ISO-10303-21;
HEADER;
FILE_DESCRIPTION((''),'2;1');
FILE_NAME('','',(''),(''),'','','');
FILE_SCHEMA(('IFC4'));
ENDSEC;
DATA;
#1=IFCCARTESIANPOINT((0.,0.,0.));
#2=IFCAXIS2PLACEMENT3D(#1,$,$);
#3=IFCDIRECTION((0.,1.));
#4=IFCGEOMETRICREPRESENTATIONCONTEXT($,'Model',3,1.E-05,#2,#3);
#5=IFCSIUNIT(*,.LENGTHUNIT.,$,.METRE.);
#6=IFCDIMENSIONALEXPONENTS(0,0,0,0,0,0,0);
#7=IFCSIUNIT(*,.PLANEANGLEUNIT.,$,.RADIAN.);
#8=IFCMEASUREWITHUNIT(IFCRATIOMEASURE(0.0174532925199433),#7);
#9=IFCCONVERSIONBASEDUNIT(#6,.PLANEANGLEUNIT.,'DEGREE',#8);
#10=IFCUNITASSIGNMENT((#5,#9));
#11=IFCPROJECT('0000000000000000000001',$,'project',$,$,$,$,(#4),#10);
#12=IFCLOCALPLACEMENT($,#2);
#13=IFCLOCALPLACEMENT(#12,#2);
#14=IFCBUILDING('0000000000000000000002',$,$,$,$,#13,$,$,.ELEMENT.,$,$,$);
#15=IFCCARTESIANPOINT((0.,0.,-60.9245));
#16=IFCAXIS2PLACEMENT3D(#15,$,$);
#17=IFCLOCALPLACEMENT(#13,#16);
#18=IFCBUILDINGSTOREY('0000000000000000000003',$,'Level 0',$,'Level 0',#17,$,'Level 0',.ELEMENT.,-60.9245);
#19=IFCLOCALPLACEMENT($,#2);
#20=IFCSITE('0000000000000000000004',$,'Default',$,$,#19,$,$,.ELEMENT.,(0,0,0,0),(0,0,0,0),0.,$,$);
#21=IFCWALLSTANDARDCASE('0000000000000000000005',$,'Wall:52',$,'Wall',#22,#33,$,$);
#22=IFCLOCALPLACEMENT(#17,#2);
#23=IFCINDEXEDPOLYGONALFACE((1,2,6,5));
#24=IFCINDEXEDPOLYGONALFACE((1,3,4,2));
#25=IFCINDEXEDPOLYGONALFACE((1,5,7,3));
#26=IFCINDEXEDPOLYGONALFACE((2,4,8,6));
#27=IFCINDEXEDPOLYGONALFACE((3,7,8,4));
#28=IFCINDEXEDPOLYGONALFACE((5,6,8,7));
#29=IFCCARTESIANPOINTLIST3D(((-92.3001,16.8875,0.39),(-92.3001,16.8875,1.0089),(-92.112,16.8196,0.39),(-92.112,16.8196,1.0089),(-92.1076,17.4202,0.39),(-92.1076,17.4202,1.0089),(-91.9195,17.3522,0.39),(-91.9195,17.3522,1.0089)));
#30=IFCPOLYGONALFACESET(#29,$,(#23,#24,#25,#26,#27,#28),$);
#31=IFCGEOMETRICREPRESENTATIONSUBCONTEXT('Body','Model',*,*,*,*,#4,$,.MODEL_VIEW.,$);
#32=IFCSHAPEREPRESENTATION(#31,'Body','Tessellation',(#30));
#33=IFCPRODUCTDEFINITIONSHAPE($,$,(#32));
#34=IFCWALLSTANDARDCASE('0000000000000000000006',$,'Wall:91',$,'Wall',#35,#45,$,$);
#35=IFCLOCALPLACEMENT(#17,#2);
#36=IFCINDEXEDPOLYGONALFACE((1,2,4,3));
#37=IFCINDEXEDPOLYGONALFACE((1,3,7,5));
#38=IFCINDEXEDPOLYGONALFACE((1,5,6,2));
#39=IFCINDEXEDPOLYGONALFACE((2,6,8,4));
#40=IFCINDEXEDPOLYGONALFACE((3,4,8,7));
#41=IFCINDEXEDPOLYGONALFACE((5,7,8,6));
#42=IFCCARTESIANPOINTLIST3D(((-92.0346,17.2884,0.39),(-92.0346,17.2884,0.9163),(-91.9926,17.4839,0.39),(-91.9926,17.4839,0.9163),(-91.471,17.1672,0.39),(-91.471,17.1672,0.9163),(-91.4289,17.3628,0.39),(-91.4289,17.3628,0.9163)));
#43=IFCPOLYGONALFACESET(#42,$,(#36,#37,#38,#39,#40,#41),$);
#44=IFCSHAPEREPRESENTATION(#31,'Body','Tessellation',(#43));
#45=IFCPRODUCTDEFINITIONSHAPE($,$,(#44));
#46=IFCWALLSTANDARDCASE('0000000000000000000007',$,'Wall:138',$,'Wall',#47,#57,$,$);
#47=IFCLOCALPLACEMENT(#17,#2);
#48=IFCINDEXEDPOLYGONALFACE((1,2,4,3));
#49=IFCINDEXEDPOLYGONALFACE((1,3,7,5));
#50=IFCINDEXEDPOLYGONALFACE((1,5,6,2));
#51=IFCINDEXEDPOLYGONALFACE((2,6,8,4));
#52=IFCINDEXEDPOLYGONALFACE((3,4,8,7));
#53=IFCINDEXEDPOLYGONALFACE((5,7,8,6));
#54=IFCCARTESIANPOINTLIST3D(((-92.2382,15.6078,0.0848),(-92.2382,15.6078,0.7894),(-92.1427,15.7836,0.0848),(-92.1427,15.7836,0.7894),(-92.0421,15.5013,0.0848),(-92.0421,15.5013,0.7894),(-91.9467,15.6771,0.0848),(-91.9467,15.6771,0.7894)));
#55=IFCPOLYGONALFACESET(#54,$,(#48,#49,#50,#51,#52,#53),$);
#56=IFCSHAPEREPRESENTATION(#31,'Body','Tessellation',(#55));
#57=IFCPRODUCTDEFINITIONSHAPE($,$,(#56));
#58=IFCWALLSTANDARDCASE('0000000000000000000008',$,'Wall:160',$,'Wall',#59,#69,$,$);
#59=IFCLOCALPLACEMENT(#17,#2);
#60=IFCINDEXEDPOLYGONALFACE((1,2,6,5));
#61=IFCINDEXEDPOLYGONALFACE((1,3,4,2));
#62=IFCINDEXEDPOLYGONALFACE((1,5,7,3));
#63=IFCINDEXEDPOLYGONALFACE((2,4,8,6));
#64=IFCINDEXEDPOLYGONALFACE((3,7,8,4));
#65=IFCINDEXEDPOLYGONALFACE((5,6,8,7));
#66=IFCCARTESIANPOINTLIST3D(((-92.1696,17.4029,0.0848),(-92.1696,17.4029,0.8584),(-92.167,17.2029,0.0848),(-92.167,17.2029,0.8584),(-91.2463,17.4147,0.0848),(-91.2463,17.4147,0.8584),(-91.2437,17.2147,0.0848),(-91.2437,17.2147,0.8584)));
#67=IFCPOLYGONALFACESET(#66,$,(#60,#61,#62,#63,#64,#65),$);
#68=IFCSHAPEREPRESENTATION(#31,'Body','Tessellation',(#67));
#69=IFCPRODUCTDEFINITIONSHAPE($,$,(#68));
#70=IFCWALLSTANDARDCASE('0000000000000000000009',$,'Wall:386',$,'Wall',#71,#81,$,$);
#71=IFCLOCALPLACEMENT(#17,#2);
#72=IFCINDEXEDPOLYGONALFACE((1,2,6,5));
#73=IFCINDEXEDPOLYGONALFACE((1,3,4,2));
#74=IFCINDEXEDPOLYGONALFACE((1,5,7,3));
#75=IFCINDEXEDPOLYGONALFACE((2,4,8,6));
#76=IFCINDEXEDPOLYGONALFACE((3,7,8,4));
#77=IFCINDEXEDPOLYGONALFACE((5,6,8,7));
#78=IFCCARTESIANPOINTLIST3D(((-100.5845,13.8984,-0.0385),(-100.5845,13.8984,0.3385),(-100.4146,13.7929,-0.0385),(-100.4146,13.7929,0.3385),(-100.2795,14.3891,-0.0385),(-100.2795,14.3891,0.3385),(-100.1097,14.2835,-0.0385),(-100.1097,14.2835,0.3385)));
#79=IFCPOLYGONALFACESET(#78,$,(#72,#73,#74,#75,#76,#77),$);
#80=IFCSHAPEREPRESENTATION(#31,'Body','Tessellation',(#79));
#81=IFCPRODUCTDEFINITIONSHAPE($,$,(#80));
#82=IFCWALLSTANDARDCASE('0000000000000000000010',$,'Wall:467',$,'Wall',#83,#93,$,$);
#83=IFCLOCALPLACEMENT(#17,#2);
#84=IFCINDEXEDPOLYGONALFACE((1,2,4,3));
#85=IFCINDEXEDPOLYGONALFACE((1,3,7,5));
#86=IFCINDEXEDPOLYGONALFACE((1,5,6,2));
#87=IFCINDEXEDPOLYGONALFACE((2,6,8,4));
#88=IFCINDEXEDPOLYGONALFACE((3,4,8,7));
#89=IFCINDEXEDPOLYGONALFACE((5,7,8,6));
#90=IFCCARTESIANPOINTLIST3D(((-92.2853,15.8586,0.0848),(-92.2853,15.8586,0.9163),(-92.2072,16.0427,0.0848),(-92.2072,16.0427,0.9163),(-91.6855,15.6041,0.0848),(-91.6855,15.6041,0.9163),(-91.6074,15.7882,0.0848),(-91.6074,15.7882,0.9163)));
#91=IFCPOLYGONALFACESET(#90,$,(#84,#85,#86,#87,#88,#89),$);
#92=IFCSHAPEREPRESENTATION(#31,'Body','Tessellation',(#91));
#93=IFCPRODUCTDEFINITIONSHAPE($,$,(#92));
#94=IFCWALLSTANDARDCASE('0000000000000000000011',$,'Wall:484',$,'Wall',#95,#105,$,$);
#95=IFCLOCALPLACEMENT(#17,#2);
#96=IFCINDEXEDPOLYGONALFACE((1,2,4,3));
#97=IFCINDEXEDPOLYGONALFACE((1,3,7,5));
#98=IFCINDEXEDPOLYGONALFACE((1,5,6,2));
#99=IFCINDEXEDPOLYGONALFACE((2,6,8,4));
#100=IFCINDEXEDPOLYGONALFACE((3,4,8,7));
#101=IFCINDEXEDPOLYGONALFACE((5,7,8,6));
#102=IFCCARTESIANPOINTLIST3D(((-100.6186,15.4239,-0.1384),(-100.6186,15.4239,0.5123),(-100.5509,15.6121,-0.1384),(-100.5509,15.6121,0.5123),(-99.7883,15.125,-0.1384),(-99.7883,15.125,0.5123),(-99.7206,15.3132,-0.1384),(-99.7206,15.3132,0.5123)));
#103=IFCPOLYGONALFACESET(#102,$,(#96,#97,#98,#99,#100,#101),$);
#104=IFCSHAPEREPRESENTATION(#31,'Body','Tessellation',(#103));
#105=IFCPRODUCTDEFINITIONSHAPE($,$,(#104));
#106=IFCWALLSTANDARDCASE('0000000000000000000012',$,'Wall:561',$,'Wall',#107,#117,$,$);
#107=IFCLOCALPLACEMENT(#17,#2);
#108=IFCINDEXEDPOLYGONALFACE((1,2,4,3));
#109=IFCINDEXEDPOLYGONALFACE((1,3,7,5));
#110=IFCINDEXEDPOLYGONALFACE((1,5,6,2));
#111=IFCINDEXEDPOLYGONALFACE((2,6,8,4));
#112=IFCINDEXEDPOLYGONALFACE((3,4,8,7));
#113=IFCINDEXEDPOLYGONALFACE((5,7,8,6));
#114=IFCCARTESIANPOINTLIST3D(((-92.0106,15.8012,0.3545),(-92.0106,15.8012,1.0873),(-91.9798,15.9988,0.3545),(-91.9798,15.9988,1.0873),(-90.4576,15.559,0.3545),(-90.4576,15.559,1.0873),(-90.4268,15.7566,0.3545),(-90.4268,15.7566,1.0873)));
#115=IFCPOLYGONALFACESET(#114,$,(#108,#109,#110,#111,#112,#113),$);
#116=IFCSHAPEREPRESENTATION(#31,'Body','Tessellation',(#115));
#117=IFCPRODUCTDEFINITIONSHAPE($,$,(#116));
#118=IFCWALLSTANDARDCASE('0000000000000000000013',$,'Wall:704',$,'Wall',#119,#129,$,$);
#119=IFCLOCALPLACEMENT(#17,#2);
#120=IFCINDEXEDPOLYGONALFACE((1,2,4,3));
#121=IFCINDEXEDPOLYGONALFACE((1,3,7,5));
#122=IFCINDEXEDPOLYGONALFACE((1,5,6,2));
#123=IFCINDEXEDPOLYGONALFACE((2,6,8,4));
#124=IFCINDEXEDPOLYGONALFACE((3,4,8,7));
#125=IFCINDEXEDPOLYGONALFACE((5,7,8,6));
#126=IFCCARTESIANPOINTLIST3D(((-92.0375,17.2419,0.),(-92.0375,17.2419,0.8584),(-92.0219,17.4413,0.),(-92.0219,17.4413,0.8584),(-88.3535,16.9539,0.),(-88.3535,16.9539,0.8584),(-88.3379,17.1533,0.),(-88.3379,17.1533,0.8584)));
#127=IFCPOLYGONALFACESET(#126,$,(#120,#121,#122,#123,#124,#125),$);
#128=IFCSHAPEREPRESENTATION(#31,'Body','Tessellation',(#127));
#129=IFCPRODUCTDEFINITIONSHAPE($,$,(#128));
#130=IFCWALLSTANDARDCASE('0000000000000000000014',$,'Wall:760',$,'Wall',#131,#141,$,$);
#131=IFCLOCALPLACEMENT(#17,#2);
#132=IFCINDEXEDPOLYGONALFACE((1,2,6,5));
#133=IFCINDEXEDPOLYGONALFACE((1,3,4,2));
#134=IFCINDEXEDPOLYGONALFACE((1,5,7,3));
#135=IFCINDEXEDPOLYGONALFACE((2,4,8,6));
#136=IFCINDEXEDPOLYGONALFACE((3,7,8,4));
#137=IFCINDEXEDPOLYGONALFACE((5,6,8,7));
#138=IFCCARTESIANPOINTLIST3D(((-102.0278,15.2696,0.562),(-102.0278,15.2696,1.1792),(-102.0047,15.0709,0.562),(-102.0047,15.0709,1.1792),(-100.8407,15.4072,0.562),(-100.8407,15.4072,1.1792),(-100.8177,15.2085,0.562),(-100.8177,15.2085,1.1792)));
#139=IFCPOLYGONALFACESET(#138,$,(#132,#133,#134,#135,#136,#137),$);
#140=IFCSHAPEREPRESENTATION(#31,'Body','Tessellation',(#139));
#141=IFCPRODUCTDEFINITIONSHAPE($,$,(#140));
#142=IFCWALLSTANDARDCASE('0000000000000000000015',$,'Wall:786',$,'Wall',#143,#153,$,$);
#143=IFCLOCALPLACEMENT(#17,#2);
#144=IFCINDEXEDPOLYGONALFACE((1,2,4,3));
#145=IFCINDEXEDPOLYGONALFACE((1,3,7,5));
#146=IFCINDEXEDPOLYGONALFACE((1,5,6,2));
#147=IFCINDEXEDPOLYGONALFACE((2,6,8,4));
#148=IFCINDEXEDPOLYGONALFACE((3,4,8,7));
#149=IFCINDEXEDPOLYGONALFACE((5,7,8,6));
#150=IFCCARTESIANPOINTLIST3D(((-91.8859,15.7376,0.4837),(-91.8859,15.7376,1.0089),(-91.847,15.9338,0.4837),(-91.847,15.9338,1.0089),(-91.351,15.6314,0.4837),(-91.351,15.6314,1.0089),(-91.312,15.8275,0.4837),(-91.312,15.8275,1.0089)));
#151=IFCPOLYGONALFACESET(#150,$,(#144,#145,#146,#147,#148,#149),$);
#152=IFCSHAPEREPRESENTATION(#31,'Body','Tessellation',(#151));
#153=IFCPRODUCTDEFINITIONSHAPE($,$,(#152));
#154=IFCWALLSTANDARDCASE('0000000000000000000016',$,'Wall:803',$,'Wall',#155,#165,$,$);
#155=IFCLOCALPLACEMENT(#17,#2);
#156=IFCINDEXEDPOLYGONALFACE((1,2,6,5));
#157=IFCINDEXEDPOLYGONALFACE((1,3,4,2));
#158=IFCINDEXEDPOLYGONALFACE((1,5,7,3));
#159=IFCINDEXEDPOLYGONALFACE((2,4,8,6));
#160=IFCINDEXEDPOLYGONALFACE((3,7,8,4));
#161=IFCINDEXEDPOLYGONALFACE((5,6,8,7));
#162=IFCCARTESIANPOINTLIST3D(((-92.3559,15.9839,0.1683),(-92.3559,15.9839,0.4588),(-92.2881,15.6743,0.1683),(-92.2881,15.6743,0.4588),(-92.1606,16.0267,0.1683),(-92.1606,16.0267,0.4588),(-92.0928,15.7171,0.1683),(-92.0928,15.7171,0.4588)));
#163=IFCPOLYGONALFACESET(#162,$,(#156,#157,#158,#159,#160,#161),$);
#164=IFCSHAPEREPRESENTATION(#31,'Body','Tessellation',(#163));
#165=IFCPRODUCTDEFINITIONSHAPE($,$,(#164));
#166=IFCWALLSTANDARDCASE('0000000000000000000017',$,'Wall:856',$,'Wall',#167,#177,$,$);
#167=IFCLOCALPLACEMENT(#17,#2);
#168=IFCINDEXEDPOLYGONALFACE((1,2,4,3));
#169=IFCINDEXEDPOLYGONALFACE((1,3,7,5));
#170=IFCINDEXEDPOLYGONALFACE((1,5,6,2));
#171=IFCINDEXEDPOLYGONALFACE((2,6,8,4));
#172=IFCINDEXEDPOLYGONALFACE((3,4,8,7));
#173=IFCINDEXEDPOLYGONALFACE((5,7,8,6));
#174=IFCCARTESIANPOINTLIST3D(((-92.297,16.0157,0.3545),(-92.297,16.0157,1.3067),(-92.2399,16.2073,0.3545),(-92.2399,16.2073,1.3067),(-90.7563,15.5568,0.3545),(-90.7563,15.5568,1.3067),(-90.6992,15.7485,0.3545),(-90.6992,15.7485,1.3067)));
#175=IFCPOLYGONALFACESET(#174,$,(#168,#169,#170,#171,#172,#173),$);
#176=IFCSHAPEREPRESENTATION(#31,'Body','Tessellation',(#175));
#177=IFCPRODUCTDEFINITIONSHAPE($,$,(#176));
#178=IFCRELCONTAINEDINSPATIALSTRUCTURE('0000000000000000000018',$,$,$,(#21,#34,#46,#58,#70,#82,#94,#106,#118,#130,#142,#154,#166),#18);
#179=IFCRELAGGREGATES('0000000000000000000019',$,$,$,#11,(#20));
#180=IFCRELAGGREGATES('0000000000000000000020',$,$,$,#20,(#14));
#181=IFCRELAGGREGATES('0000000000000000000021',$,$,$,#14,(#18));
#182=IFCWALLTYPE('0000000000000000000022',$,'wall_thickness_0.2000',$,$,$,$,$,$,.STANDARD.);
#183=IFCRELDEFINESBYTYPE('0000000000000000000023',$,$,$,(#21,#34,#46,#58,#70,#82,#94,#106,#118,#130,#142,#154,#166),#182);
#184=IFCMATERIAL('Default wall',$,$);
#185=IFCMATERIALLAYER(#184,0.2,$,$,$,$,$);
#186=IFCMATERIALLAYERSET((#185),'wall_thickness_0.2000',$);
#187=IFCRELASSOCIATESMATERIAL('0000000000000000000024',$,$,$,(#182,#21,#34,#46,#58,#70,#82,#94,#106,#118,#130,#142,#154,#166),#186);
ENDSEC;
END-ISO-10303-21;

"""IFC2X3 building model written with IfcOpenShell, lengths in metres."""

from ifc_helpers import new_model, entity, si_unit, converted_unit, direction, frame, origin, place, context, subcontext, project, spatial, polyline, outline, extrude, material, layer, layer_set, layer_usage, type_object, element, save


model = new_model("IFC2X3")

# Units and contexts
model_context = context("Model", 3, precision=1e-05, world=origin(), true_north=direction((0.0, 1.0)))
body_context = subcontext(model_context, "Body", "Model", "MODEL_VIEW")
ifc_project = project(units=[si_unit("LENGTHUNIT", "METRE"), converted_unit("PLANEANGLEUNIT", "DEGREE", entity("IfcRatioMeasure", 0.0174532925199433), si_unit("PLANEANGLEUNIT", "RADIAN"), dimensions=[0, 0, 0, 0, 0, 0, 0])], contexts=[model_context])

# Site, building, storey
site_placement = place(None, origin())
site = spatial("IfcSite", under=ifc_project, at=site_placement, Name="Default", CompositionType="ELEMENT", RefLatitude=(0, 0, 0, 0), RefLongitude=(0, 0, 0, 0), RefElevation=0.0)
placement_1 = place(None, origin())
building_placement = place(placement_1, origin())
building = spatial("IfcBuilding", under=site, at=building_placement, CompositionType="ELEMENT")
storey_placement = place(building_placement, frame((0.0, 0.0, -60.9245)))
storey = spatial("IfcBuildingStorey", under=building, at=storey_placement, Name="Level 0", ObjectType="Level 0", LongName="Level 0", CompositionType="ELEMENT", Elevation=-60.9245)

# Walls
ifc_material = material(Name="Default wall")
ifc_layer = layer(ifc_material, 0.2)
ifc_layer_set = layer_set([ifc_layer], Name="wall_thickness_0.2000")
ifc_layer_usage = layer_usage(ifc_layer_set, "AXIS2", "POSITIVE", -0.1)
wall_type = type_object("IfcWallType", Name="wall_thickness_0.2000", PredefinedType="STANDARD", material=ifc_layer_set)
placement_2 = place(building_placement, frame((0.0, 0.0, -60.5345)))
wall_1_placement = place(placement_2, frame((-92.2061, 16.8536, 0.0), z_axis=(0.0, 0.0, 1.0), x_axis=(0.339834, 0.940485, 0.0)))
element("IfcWallStandardCase", 1, at=wall_1_placement, inside=storey, type_object=wall_type, material=ifc_layer_usage, Name="Wall:52", ObjectType="Wall", context=body_context, shape_type="SweptSolid", body=[
    extrude(outline(polyline([(0.5663, -0.1), (0.5663, 0.1), (0.0, 0.1), (0.0, -0.1), (0.5663, -0.1)])), origin(), (0.0, 0.0, 1.0), 0.6189),
])
placement_3 = place(building_placement, frame((0.0, 0.0, -60.5345)))
wall_2_placement = place(placement_3, frame((-92.0136, 17.3862, 0.0), z_axis=(0.0, 0.0, 1.0), x_axis=(0.977661, -0.210187, 0.0)))
element("IfcWallStandardCase", 2, at=wall_2_placement, inside=storey, type_object=wall_type, material=ifc_layer_usage, Name="Wall:91", ObjectType="Wall", context=body_context, shape_type="SweptSolid", body=[
    extrude(outline(polyline([(0.5765, -0.1), (0.5765, 0.1), (0.0, 0.1), (0.0, -0.1), (0.5765, -0.1)])), origin(), (0.0, 0.0, 1.0), 0.5263),
])
placement_4 = place(building_placement, frame((0.0, 0.0, -60.8397)))
wall_3_placement = place(placement_4, frame((-91.9944, 15.5892, 0.0), z_axis=(0.0, 0.0, 1.0), x_axis=(-0.878801, 0.477188, 0.0)))
element("IfcWallStandardCase", 3, at=wall_3_placement, inside=storey, type_object=wall_type, material=ifc_layer_usage, Name="Wall:138", ObjectType="Wall", context=body_context, shape_type="SweptSolid", body=[
    extrude(outline(polyline([(0.2231, -0.1), (0.2231, 0.1), (0.0, 0.1), (0.0, -0.1), (0.2231, -0.1)])), origin(), (0.0, 0.0, 1.0), 0.7047),
])
placement_5 = place(building_placement, frame((0.0, 0.0, -60.8397)))
wall_4_placement = place(placement_5, frame((-92.1683, 17.3029, 0.0), z_axis=(0.0, 0.0, 1.0), x_axis=(0.999919, 0.012766, 0.0)))
element("IfcWallStandardCase", 4, at=wall_4_placement, inside=storey, type_object=wall_type, material=ifc_layer_usage, Name="Wall:160", ObjectType="Wall", context=body_context, shape_type="SweptSolid", body=[
    extrude(outline(polyline([(0.9234, -0.1), (0.9234, 0.1), (0.0, 0.1), (0.0, -0.1), (0.9234, -0.1)])), origin(), (0.0, 0.0, 1.0), 0.7736),
])
placement_6 = place(building_placement, frame((0.0, 0.0, -60.963)))
wall_5_placement = place(placement_6, frame((-100.4995, 13.8457, 0.0), z_axis=(0.0, 0.0, 1.0), x_axis=(0.527909, 0.849301, 0.0)))
element("IfcWallStandardCase", 5, at=wall_5_placement, inside=storey, type_object=wall_type, material=ifc_layer_usage, Name="Wall:386", ObjectType="Wall", context=body_context, shape_type="SweptSolid", body=[
    extrude(outline(polyline([(0.5777, -0.1), (0.5777, 0.1), (0.0, 0.1), (0.0, -0.1), (0.5777, -0.1)])), origin(), (0.0, 0.0, 1.0), 0.3771),
])
placement_7 = place(building_placement, frame((0.0, 0.0, -60.8397)))
wall_6_placement = place(placement_7, frame((-91.6465, 15.6961, 0.0), z_axis=(0.0, 0.0, 1.0), x_axis=(-0.920568, 0.390582, 0.0)))
element("IfcWallStandardCase", 6, at=wall_6_placement, inside=storey, type_object=wall_type, material=ifc_layer_usage, Name="Wall:467", ObjectType="Wall", context=body_context, shape_type="SweptSolid", body=[
    extrude(outline(polyline([(0.6516, -0.1), (0.6516, 0.1), (0.0, 0.1), (0.0, -0.1), (0.6516, -0.1)])), origin(), (0.0, 0.0, 1.0), 0.8315),
])
placement_8 = place(building_placement, frame((0.0, 0.0, -61.0629)))
wall_7_placement = place(placement_8, frame((-99.7545, 15.2191, 0.0), z_axis=(0.0, 0.0, 1.0), x_axis=(-0.940894, 0.338702, 0.0)))
element("IfcWallStandardCase", 7, at=wall_7_placement, inside=storey, type_object=wall_type, material=ifc_layer_usage, Name="Wall:484", ObjectType="Wall", context=body_context, shape_type="SweptSolid", body=[
    extrude(outline(polyline([(0.8824, -0.1), (0.8824, 0.1), (0.0, 0.1), (0.0, -0.1), (0.8824, -0.1)])), origin(), (0.0, 0.0, 1.0), 0.6506),
])
placement_9 = place(building_placement, frame((0.0, 0.0, -60.57)))
wall_8_placement = place(placement_9, frame((-91.9952, 15.9, 0.0), z_axis=(0.0, 0.0, 1.0), x_axis=(0.988051, -0.154127, 0.0)))
element("IfcWallStandardCase", 8, at=wall_8_placement, inside=storey, type_object=wall_type, material=ifc_layer_usage, Name="Wall:561", ObjectType="Wall", context=body_context, shape_type="SweptSolid", body=[
    extrude(outline(polyline([(1.5718, -0.1), (1.5718, 0.1), (0.0, 0.1), (0.0, -0.1), (1.5718, -0.1)])), origin(), (0.0, 0.0, 1.0), 0.7328),
])
wall_9_placement = place(storey_placement, frame((-92.0297, 17.3416, 0.0), z_axis=(0.0, 0.0, 1.0), x_axis=(0.996958, -0.077939, 0.0)))
element("IfcWallStandardCase", 9, at=wall_9_placement, inside=storey, type_object=wall_type, material=ifc_layer_usage, Name="Wall:704", ObjectType="Wall", context=body_context, shape_type="SweptSolid", body=[
    extrude(outline(polyline([(3.6952, -0.1), (3.6952, 0.1), (0.0, 0.1), (0.0, -0.1), (3.6952, -0.1)])), origin(), (0.0, 0.0, 1.0), 0.8584),
])
placement_10 = place(building_placement, frame((0.0, 0.0, -60.3625)))
wall_10_placement = place(placement_10, frame((-102.0162, 15.1702, 0.0), z_axis=(0.0, 0.0, 1.0), x_axis=(0.993346, 0.115169, 0.0)))
element("IfcWallStandardCase", 10, at=wall_10_placement, inside=storey, type_object=wall_type, material=ifc_layer_usage, Name="Wall:760", ObjectType="Wall", context=body_context, shape_type="SweptSolid", body=[
    extrude(outline(polyline([(1.195, -0.1), (1.195, 0.1), (0.0, 0.1), (0.0, -0.1), (1.195, -0.1)])), origin(), (0.0, 0.0, 1.0), 0.6172),
])
placement_11 = place(building_placement, frame((0.0, 0.0, -60.4408)))
wall_11_placement = place(placement_11, frame((-91.8665, 15.8357, 0.0), z_axis=(0.0, 0.0, 1.0), x_axis=(0.980832, -0.194856, 0.0)))
element("IfcWallStandardCase", 11, at=wall_11_placement, inside=storey, type_object=wall_type, material=ifc_layer_usage, Name="Wall:786", ObjectType="Wall", context=body_context, shape_type="SweptSolid", body=[
    extrude(outline(polyline([(0.5454, -0.1), (0.5454, 0.1), (0.0, 0.1), (0.0, -0.1), (0.5454, -0.1)])), origin(), (0.0, 0.0, 1.0), 0.5252),
])
placement_12 = place(building_placement, frame((0.0, 0.0, -60.7562)))
wall_12_placement = place(placement_12, frame((-92.2582, 16.0053, 0.0), z_axis=(0.0, 0.0, 1.0), x_axis=(0.213895, -0.976857, 0.0)))
element("IfcWallStandardCase", 12, at=wall_12_placement, inside=storey, type_object=wall_type, material=ifc_layer_usage, Name="Wall:803", ObjectType="Wall", context=body_context, shape_type="SweptSolid", body=[
    extrude(outline(polyline([(0.3169, -0.1), (0.3169, 0.1), (0.0, 0.1), (0.0, -0.1), (0.3169, -0.1)])), origin(), (0.0, 0.0, 1.0), 0.2905),
])
placement_13 = place(building_placement, frame((0.0, 0.0, -60.57)))
wall_13_placement = place(placement_13, frame((-92.2684, 16.1115, 0.0), z_axis=(0.0, 0.0, 1.0), x_axis=(0.958399, -0.285432, 0.0)))
element("IfcWallStandardCase", 13, at=wall_13_placement, inside=storey, type_object=wall_type, material=ifc_layer_usage, Name="Wall:856", ObjectType="Wall", context=body_context, shape_type="SweptSolid", body=[
    extrude(outline(polyline([(1.6075, -0.1), (1.6075, 0.1), (0.0, 0.1), (0.0, -0.1), (1.6075, -0.1)])), origin(), (0.0, 0.0, 1.0), 0.9522),
])

save(model, "model.ifc")
